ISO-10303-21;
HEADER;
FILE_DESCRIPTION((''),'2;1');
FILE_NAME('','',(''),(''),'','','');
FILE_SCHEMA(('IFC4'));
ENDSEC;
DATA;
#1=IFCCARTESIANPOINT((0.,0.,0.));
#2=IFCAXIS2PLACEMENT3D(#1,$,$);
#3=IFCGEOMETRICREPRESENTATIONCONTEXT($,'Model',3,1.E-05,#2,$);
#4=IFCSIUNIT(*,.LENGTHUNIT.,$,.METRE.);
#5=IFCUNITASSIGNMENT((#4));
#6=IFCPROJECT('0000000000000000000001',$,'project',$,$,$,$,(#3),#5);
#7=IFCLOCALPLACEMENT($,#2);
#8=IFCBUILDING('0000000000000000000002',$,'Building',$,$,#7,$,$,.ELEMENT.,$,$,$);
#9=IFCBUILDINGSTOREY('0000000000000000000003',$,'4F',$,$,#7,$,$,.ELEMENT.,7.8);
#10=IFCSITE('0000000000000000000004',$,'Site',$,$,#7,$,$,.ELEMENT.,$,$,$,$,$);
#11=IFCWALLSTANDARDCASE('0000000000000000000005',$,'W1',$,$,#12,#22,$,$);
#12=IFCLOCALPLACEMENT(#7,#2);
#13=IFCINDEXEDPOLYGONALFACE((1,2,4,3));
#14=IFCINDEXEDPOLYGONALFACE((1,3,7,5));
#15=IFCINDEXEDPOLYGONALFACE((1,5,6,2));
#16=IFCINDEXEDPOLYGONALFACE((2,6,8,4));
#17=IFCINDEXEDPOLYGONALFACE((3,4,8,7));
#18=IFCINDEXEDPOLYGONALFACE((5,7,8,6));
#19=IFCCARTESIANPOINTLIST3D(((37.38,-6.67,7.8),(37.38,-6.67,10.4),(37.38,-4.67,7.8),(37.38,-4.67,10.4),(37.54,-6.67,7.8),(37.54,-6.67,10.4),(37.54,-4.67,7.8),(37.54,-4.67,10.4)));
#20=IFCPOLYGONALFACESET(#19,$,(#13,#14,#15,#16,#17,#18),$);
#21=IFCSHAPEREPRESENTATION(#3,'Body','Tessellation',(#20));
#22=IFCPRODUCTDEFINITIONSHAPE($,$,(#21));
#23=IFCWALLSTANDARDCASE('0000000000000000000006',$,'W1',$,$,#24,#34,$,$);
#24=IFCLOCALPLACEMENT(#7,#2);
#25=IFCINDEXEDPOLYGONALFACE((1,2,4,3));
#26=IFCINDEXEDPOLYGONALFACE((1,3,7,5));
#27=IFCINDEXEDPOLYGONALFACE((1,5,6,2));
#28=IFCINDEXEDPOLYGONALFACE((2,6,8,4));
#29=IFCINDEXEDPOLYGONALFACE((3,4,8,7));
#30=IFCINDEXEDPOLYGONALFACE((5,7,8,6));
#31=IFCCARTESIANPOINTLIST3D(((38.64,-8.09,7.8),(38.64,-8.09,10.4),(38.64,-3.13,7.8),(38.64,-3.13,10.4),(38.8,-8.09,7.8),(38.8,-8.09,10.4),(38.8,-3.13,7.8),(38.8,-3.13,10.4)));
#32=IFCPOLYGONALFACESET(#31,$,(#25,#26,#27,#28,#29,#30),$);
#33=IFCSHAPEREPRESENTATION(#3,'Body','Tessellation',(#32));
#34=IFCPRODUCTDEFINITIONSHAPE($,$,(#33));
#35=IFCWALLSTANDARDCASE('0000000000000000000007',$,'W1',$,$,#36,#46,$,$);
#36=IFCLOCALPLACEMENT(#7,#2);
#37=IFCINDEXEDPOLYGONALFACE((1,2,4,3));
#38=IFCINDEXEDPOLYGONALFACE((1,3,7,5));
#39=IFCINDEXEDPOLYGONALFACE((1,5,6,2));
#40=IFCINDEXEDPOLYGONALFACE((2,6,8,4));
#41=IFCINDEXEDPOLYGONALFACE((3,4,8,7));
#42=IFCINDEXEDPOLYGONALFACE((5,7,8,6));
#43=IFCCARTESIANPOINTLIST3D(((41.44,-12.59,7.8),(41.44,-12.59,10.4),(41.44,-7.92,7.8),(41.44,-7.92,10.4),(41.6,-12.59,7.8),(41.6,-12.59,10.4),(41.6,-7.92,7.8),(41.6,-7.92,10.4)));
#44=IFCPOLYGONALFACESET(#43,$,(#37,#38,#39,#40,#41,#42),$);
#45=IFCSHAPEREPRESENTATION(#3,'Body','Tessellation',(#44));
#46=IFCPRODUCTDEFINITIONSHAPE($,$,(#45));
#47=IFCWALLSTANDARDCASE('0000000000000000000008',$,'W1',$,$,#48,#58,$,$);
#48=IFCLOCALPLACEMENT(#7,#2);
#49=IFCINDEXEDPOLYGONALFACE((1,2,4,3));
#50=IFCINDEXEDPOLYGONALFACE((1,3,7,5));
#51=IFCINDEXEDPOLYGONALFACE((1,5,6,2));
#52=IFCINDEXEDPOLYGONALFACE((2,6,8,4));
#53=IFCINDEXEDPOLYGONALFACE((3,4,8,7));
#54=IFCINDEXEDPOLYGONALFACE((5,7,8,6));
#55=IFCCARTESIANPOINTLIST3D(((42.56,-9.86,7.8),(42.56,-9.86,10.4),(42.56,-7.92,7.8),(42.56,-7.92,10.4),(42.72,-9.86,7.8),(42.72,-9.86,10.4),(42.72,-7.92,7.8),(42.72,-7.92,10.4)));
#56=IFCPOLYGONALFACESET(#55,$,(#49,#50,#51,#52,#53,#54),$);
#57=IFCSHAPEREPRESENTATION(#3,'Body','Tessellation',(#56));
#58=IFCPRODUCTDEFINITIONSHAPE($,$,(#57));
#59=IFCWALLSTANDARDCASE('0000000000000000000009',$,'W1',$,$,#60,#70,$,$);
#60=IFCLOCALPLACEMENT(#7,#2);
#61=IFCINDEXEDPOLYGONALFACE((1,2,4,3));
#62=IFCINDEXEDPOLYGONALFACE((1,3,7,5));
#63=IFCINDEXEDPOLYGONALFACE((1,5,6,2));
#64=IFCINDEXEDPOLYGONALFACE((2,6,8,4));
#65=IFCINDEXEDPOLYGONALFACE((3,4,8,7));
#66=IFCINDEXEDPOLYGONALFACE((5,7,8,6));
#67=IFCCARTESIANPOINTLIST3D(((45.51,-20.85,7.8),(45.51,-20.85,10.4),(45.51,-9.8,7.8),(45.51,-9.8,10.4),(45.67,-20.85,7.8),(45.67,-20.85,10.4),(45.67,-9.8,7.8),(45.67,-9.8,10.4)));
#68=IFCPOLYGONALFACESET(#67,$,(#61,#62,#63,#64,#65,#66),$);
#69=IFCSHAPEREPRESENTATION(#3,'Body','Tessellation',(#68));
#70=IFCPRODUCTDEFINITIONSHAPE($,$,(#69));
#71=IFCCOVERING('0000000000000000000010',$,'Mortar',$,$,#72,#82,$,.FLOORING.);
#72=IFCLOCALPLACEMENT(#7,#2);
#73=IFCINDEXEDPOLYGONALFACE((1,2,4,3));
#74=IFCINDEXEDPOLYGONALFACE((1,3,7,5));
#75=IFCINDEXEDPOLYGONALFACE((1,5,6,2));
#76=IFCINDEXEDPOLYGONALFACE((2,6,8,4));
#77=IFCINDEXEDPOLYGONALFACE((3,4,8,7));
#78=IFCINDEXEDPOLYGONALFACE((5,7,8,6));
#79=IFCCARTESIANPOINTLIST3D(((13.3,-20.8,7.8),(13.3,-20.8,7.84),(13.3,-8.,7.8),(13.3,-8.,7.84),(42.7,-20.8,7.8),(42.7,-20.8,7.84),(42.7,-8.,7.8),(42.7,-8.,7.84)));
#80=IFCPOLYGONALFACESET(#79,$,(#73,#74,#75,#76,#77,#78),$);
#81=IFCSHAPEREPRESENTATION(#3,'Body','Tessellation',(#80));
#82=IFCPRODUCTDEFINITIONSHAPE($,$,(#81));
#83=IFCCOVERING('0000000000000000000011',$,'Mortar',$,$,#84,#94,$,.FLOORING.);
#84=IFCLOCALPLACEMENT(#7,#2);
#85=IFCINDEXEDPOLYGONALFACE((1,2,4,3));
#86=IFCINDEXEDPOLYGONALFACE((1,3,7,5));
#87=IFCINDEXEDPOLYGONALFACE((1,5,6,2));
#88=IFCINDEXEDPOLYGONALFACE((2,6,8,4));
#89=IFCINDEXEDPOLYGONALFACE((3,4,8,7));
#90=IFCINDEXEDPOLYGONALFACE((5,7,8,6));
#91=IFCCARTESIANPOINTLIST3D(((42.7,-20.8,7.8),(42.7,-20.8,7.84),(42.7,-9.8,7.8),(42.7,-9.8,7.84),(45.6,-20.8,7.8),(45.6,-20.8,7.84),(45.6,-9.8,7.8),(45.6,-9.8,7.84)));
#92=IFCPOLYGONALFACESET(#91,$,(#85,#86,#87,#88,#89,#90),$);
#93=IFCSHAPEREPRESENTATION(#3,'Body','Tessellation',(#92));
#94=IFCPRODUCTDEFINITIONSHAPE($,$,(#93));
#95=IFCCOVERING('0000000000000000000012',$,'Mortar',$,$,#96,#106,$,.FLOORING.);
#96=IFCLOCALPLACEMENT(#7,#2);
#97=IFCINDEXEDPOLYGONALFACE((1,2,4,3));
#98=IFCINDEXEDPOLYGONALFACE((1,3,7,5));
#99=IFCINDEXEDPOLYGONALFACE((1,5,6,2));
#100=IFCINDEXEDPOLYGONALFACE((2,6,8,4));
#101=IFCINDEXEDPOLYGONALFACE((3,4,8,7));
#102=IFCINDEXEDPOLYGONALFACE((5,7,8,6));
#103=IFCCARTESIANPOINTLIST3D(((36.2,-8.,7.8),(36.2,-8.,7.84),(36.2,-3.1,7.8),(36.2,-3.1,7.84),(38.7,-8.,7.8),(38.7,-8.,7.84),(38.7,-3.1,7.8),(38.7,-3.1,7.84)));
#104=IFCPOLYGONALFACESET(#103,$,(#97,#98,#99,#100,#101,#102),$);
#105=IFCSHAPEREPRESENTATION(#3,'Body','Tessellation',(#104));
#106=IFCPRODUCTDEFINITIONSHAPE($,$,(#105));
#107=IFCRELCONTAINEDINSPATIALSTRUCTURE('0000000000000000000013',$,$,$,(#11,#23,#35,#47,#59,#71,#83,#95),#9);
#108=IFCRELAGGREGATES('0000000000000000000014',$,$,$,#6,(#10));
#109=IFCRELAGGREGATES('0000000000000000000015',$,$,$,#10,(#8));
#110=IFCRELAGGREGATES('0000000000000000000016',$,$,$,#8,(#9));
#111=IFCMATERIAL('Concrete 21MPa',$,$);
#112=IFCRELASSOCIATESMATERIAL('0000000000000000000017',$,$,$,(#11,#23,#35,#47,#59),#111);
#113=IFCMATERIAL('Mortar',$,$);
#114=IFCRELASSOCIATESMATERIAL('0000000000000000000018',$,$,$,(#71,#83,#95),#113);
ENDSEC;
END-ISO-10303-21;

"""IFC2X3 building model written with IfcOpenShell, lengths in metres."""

from ifc_helpers import new_model, si_unit, frame, origin, origin_2d, place, context, project, spatial, rectangle, extrude, material, element, save


model = new_model("IFC2X3")

# Units and contexts
model_context = context("Model", 3, precision=1e-05, world=origin())
ifc_project = project(units=[si_unit("LENGTHUNIT", "METRE")], contexts=[model_context])

# Site, building, storey
placement = place(None, origin())
site = spatial("IfcSite", under=ifc_project, at=placement, Name="Site", CompositionType="ELEMENT")
building = spatial("IfcBuilding", under=site, at=placement, Name="Building", CompositionType="ELEMENT")
storey = spatial("IfcBuildingStorey", under=building, at=placement, Name="4F", CompositionType="ELEMENT", Elevation=7.8)

# Shared definitions
ifc_material_1 = material(Name="Concrete 21MPa")

# Walls
wall_1_placement = place(None, frame((37.46, -5.67, 7.8)))
element("IfcWallStandardCase", 1, at=wall_1_placement, inside=storey, material=ifc_material_1, Name="W1", context=model_context, shape_type="SweptSolid", body=[
    extrude(rectangle(XDim=0.16, YDim=2.0, at=origin_2d()), origin(), (0.0, 0.0, 1.0), 2.6),
])
wall_2_placement = place(None, frame((38.72, -5.61, 7.8)))
element("IfcWallStandardCase", 2, at=wall_2_placement, inside=storey, material=ifc_material_1, Name="W1", context=model_context, shape_type="SweptSolid", body=[
    extrude(rectangle(XDim=0.16, YDim=4.96, at=origin_2d()), origin(), (0.0, 0.0, 1.0), 2.6),
])
wall_3_placement = place(None, frame((41.52, -10.255, 7.8)))
element("IfcWallStandardCase", 3, at=wall_3_placement, inside=storey, material=ifc_material_1, Name="W1", context=model_context, shape_type="SweptSolid", body=[
    extrude(rectangle(XDim=0.16, YDim=4.67, at=origin_2d()), origin(), (0.0, 0.0, 1.0), 2.6),
])
wall_4_placement = place(None, frame((42.64, -8.89, 7.8)))
element("IfcWallStandardCase", 4, at=wall_4_placement, inside=storey, material=ifc_material_1, Name="W1", context=model_context, shape_type="SweptSolid", body=[
    extrude(rectangle(XDim=0.16, YDim=1.94, at=origin_2d()), origin(), (0.0, 0.0, 1.0), 2.6),
])
wall_5_placement = place(None, frame((45.59, -15.325, 7.8)))
element("IfcWallStandardCase", 5, at=wall_5_placement, inside=storey, material=ifc_material_1, Name="W1", context=model_context, shape_type="SweptSolid", body=[
    extrude(rectangle(XDim=0.16, YDim=11.05, at=origin_2d()), origin(), (0.0, 0.0, 1.0), 2.6),
])

# Coverings
ifc_material_2 = material(Name="Mortar")
covering_1_placement = place(None, frame((28.0, -14.4, 7.8)))
element("IfcCovering", 6, at=covering_1_placement, inside=storey, material=ifc_material_2, Name="Mortar", PredefinedType="FLOORING", context=model_context, shape_type="SweptSolid", body=[
    extrude(rectangle(XDim=29.4, YDim=12.8, at=origin_2d()), origin(), (0.0, 0.0, 1.0), 0.04),
])
covering_2_placement = place(None, frame((44.15, -15.3, 7.8)))
element("IfcCovering", 7, at=covering_2_placement, inside=storey, material=ifc_material_2, Name="Mortar", PredefinedType="FLOORING", context=model_context, shape_type="SweptSolid", body=[
    extrude(rectangle(XDim=2.9, YDim=11.0, at=origin_2d()), origin(), (0.0, 0.0, 1.0), 0.04),
])
covering_3_placement = place(None, frame((37.45, -5.55, 7.8)))
element("IfcCovering", 8, at=covering_3_placement, inside=storey, material=ifc_material_2, Name="Mortar", PredefinedType="FLOORING", context=model_context, shape_type="SweptSolid", body=[
    extrude(rectangle(XDim=2.5, YDim=4.9, at=origin_2d()), origin(), (0.0, 0.0, 1.0), 0.04),
])

save(model, "model.ifc")
